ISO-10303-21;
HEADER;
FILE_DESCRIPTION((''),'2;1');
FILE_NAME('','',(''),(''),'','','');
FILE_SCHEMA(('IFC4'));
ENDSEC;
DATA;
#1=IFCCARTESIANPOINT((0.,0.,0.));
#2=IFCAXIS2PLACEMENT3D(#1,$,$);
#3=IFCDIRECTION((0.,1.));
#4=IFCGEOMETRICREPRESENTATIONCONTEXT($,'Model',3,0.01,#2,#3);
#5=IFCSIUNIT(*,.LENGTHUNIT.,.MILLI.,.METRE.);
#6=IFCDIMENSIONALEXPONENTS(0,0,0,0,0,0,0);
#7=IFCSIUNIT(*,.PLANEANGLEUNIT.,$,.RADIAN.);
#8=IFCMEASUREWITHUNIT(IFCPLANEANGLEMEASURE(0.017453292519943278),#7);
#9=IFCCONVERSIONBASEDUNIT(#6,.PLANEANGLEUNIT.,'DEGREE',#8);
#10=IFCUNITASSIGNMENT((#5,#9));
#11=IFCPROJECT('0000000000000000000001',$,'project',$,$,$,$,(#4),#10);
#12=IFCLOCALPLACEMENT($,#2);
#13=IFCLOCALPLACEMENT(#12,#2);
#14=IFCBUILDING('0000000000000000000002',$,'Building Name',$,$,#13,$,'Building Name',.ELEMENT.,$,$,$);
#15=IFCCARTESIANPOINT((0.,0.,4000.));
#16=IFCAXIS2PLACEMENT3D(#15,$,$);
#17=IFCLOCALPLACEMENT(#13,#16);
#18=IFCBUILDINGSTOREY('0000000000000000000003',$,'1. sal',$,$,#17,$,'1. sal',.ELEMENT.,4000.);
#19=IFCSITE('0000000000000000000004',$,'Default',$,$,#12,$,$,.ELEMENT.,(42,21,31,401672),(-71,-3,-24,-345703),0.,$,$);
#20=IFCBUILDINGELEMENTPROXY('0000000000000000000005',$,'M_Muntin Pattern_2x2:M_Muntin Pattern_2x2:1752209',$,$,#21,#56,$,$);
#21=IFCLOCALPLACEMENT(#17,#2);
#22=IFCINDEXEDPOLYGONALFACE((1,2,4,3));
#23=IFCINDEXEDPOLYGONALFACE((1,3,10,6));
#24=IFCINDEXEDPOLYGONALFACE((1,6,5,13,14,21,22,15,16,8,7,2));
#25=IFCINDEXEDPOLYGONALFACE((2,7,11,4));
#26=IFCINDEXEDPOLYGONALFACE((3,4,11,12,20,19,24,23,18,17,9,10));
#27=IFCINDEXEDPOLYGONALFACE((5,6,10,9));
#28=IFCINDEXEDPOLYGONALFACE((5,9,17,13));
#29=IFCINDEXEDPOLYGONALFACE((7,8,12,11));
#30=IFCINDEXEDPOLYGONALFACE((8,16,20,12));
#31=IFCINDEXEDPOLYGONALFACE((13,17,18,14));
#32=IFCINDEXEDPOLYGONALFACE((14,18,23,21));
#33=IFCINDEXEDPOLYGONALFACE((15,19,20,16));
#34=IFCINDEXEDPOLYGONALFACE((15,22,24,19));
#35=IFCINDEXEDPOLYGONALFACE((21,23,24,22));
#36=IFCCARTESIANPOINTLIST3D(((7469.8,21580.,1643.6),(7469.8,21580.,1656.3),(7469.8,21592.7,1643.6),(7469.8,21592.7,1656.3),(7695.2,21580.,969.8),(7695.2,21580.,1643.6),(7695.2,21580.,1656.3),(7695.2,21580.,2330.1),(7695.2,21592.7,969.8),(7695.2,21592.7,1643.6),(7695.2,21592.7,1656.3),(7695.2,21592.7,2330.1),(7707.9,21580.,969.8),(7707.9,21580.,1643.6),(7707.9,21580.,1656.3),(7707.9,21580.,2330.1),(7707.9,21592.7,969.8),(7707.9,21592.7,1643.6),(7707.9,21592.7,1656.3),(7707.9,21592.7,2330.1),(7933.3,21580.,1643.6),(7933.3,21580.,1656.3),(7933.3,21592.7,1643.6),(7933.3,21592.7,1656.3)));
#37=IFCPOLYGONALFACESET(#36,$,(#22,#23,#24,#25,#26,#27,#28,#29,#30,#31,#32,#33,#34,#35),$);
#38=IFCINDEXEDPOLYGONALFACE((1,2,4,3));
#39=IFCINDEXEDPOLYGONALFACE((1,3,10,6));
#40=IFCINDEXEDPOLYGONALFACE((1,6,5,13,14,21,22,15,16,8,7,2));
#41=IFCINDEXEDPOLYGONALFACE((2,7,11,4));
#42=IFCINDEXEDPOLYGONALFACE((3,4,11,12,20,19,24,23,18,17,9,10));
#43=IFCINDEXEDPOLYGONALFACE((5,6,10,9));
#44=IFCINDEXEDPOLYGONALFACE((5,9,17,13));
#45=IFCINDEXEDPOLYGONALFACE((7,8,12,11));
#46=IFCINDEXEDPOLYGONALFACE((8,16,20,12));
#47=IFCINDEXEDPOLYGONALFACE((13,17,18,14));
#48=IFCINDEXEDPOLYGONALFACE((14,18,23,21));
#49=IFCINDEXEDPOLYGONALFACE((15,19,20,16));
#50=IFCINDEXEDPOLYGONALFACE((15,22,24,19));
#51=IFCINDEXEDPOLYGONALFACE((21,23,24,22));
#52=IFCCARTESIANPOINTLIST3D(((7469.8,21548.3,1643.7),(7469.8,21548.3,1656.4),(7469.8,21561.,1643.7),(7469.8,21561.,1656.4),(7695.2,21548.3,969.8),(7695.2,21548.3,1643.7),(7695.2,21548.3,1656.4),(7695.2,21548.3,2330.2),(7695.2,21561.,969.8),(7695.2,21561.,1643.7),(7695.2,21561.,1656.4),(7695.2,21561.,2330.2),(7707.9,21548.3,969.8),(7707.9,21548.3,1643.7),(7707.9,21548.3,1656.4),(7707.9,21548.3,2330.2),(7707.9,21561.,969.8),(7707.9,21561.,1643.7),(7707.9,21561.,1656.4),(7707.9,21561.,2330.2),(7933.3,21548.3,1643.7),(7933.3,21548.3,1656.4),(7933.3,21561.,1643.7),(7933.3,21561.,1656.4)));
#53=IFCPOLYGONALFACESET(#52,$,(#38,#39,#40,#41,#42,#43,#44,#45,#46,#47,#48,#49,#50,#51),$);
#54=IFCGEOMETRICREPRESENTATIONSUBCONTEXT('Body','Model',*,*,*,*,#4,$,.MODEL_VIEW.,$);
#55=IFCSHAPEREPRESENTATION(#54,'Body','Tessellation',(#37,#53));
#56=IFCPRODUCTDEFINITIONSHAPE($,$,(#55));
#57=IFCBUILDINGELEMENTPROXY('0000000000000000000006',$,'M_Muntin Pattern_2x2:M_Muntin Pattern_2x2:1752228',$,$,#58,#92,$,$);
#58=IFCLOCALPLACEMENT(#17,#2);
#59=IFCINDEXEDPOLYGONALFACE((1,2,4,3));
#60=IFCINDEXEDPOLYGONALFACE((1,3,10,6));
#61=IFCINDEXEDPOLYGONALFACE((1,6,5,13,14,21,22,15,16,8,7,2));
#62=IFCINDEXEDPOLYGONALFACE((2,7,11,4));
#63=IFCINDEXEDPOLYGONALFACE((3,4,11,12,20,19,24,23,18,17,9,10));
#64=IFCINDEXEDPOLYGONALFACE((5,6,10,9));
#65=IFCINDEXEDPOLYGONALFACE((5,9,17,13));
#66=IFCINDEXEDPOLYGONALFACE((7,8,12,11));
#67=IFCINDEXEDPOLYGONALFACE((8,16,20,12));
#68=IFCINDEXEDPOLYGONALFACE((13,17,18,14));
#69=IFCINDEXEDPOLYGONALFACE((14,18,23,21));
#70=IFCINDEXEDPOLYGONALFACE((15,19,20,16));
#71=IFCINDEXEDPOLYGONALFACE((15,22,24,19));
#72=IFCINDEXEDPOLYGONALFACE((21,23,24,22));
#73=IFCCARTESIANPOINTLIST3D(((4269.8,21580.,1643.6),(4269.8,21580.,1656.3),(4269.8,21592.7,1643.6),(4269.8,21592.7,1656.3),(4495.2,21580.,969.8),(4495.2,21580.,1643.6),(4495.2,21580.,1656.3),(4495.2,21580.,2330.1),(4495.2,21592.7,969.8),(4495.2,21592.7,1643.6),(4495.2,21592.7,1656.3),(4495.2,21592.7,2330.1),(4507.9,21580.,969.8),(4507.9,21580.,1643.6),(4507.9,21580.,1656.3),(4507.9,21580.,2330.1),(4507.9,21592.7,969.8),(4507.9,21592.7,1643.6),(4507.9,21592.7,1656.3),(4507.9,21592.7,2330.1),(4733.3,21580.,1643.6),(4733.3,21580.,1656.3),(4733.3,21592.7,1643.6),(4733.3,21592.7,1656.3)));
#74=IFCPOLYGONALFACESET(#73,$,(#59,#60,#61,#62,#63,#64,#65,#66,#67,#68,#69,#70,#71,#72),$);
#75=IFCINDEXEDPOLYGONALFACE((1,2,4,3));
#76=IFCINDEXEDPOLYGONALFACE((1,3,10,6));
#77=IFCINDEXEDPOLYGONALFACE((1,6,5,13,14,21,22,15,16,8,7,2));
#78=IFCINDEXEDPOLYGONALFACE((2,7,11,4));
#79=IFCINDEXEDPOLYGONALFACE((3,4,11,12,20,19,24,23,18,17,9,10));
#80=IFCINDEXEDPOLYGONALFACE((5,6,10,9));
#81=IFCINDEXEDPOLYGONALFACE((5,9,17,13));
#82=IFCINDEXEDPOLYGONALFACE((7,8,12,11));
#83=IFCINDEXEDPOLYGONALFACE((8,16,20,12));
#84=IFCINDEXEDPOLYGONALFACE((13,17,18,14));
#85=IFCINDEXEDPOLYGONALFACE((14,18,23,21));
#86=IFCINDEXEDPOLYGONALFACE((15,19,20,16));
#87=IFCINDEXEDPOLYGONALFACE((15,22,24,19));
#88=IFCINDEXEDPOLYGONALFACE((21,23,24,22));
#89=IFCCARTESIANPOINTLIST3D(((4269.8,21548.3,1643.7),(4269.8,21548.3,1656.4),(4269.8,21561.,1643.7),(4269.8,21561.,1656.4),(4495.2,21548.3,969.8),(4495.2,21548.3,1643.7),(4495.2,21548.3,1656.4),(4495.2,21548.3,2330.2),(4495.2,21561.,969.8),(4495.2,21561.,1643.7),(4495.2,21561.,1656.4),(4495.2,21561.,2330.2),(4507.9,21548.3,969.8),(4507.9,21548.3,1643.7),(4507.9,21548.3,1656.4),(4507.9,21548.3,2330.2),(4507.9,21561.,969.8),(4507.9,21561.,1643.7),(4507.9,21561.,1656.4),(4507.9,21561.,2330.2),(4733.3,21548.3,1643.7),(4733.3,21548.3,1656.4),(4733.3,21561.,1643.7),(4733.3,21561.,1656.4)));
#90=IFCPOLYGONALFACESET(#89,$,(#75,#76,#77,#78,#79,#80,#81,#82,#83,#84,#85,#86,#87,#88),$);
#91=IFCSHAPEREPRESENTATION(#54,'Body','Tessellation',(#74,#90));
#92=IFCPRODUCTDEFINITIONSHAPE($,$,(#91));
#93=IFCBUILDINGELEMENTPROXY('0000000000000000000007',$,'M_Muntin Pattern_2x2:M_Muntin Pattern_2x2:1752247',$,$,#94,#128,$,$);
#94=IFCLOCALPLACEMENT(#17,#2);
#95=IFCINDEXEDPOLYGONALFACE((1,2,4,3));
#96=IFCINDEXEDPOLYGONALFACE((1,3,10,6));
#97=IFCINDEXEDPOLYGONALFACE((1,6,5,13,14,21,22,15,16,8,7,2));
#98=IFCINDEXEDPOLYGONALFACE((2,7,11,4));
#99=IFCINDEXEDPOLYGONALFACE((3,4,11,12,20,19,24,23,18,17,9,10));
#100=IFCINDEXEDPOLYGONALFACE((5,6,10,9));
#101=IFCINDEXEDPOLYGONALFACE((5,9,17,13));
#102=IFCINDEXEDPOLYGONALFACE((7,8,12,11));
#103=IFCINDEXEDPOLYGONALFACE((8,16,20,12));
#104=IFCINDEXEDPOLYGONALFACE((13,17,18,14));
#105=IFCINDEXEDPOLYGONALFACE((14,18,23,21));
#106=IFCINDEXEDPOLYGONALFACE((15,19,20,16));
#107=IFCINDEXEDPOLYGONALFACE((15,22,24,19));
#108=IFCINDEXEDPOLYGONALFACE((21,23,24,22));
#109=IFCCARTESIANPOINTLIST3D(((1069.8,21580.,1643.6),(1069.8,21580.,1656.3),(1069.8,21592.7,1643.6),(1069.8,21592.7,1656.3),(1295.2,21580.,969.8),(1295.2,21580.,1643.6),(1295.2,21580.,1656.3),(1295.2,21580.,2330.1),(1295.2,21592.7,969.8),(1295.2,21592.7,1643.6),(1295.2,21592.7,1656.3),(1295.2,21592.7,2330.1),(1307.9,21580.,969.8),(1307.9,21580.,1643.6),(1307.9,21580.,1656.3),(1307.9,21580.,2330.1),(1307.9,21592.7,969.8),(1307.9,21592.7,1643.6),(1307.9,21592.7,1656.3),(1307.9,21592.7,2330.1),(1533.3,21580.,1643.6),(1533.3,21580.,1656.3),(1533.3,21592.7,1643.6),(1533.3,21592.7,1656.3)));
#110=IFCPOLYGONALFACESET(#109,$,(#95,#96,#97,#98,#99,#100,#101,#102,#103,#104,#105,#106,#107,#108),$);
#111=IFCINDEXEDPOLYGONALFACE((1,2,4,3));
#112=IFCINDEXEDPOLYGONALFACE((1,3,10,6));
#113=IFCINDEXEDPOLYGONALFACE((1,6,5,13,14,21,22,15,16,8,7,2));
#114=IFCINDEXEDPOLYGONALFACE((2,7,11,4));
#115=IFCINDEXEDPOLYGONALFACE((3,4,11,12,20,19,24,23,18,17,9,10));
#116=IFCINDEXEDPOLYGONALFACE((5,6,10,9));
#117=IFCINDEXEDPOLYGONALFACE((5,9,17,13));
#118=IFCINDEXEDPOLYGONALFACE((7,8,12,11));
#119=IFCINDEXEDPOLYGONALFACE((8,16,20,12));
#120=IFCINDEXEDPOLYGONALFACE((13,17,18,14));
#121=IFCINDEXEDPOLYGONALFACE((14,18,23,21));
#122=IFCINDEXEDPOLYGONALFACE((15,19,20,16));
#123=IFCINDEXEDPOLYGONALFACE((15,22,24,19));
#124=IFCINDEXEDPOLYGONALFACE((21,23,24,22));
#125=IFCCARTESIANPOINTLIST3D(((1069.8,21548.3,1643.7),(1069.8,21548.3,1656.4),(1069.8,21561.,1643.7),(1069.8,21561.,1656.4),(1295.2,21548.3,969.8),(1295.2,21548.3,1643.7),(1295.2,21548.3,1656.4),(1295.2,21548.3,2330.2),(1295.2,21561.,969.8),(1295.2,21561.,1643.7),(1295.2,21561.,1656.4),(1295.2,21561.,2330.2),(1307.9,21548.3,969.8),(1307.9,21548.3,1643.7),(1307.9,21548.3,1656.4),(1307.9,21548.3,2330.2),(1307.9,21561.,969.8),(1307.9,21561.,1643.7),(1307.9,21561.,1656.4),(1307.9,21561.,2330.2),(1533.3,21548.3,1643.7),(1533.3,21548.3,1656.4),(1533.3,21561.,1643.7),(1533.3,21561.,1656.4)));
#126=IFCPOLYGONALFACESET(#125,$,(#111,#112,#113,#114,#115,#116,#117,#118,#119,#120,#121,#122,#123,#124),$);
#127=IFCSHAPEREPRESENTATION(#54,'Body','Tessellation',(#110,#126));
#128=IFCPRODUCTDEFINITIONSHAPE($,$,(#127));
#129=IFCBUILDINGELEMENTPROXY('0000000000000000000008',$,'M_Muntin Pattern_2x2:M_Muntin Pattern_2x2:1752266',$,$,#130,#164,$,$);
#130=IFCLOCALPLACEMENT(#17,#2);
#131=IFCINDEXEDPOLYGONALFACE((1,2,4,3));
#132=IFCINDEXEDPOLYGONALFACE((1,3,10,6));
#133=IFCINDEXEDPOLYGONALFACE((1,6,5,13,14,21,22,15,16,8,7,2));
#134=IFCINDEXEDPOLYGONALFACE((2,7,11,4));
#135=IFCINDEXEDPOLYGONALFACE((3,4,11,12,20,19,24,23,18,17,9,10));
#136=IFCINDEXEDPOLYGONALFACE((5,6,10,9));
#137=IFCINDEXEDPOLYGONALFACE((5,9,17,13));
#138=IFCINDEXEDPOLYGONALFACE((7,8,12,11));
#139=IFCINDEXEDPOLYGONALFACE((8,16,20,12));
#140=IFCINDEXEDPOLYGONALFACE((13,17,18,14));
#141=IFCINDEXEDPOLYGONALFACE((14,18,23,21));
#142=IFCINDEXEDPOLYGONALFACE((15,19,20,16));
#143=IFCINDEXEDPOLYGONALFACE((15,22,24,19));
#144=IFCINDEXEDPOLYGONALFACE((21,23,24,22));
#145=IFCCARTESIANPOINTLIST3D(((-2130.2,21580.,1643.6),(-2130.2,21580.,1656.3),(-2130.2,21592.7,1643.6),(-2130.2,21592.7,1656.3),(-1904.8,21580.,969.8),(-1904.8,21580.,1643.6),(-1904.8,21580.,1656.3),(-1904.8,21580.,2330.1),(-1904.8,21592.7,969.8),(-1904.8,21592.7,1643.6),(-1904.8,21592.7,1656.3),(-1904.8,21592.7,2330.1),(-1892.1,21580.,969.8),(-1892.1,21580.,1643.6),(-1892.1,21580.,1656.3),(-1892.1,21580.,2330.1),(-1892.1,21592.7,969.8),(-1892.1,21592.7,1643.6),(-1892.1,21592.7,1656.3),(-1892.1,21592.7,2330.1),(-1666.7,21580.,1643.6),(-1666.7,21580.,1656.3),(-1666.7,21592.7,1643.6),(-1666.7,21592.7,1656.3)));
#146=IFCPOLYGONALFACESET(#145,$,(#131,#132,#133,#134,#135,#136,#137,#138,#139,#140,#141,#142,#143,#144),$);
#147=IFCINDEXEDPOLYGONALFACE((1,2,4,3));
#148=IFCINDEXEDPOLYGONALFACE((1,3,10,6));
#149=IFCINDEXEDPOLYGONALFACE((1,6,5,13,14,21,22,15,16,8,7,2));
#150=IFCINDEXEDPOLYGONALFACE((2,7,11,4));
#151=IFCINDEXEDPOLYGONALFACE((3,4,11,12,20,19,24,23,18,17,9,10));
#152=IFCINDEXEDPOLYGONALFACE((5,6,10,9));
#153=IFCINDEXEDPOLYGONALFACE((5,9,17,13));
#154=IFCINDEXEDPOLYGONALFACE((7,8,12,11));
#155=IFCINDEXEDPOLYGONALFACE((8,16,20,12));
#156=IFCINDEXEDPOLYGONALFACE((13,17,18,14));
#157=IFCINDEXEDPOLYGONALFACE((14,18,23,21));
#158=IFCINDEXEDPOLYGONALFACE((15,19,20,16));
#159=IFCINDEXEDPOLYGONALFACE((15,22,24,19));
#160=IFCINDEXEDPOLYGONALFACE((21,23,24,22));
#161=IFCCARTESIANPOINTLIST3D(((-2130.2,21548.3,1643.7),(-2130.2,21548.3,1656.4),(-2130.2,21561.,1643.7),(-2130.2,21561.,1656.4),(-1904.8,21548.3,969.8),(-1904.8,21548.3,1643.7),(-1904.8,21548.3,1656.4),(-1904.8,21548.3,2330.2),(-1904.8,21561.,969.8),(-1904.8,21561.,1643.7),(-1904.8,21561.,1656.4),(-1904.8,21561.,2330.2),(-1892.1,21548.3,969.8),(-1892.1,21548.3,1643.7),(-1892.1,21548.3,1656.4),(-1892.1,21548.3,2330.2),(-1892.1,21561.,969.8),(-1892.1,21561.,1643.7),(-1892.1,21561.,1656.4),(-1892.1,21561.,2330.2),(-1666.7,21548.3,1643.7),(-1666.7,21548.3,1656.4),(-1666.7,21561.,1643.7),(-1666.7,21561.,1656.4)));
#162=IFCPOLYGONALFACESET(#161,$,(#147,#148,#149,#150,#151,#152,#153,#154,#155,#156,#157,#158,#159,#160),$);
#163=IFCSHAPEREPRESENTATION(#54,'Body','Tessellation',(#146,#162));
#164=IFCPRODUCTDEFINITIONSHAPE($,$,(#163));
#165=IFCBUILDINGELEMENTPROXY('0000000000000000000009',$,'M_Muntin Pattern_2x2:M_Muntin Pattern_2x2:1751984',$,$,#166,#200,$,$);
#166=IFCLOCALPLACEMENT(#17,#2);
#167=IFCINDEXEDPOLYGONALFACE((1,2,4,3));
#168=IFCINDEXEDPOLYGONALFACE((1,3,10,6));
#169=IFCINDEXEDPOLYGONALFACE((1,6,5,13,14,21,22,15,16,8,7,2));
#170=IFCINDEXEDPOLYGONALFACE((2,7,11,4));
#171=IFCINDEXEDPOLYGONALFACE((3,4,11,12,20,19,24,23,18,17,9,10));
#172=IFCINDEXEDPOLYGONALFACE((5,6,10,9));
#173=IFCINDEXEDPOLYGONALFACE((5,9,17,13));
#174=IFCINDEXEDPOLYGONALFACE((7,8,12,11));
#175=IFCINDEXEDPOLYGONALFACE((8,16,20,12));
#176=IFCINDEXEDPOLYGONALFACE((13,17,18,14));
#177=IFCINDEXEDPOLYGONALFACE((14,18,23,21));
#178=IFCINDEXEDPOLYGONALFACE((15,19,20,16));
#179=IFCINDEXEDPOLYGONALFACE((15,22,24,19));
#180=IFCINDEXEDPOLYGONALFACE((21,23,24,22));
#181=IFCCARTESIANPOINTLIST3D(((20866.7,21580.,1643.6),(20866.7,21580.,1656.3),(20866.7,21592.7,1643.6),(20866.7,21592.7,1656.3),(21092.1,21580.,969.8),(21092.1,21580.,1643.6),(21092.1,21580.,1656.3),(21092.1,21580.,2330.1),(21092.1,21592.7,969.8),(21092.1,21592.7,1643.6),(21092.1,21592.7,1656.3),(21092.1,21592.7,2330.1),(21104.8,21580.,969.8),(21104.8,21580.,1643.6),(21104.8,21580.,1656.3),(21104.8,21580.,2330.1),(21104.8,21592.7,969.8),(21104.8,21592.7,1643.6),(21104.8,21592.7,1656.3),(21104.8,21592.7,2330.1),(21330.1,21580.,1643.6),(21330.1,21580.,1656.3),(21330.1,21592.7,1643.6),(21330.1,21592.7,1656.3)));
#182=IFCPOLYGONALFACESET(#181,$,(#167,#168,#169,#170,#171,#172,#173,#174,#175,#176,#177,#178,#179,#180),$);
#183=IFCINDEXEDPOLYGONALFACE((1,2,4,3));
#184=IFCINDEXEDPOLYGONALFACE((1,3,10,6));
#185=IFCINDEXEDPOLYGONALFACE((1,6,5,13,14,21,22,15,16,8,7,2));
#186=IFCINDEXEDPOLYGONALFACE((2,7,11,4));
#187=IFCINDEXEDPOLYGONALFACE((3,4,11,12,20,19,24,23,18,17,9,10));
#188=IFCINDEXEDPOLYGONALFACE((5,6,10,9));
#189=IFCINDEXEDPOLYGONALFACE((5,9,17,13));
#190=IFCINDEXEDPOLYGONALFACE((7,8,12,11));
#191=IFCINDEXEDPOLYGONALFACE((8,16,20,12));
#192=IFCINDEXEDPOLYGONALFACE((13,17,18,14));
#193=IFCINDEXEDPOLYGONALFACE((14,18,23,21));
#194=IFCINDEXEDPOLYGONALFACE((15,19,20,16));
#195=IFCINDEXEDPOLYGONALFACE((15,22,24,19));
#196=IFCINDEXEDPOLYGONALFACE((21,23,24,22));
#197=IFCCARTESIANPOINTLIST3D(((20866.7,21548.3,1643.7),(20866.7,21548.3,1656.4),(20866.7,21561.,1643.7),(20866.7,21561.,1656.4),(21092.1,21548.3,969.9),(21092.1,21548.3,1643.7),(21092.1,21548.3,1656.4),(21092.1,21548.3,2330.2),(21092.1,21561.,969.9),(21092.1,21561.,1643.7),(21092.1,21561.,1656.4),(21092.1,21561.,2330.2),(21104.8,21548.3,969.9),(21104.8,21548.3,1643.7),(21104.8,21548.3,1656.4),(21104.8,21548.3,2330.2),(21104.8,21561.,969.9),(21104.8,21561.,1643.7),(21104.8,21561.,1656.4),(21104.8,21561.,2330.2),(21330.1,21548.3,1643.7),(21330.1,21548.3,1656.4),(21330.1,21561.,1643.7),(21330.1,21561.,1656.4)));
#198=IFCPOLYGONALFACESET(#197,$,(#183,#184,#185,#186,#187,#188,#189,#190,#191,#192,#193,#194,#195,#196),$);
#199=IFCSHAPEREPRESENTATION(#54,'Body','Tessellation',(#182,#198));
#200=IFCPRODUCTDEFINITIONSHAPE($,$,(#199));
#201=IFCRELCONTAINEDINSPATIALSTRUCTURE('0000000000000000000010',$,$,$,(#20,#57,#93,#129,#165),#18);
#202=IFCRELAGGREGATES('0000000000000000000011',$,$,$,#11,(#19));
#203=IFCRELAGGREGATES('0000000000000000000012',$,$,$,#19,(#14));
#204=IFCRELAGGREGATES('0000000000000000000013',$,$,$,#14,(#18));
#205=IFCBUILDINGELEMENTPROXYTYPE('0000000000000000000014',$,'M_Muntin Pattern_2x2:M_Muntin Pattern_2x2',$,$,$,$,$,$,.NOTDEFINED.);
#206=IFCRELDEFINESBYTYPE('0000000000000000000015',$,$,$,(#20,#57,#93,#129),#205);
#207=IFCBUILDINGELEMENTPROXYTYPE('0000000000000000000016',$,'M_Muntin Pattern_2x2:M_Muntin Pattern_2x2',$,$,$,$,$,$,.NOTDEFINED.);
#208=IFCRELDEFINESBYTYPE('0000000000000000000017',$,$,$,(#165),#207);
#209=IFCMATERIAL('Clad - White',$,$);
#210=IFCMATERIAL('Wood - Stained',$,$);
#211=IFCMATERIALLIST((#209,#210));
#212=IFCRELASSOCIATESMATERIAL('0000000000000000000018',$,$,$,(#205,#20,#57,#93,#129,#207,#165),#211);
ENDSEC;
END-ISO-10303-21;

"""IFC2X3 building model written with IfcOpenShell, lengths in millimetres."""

from ifc_helpers import new_model, entity, si_unit, converted_unit, direction, frame, origin, place, context, subcontext, project, spatial, polyline, outline, extrude, source, transform, mapped, material, material_list, type_object, type_shapes, element, save


model = new_model("IFC2X3")

# Units and contexts
model_context = context("Model", 3, precision=0.01, world=origin(), true_north=direction((0.0, 1.0)))
body_context = subcontext(model_context, "Body", "Model", "MODEL_VIEW")
ifc_project = project(units=[si_unit("LENGTHUNIT", "METRE", prefix="MILLI"), converted_unit("PLANEANGLEUNIT", "DEGREE", entity("IfcPlaneAngleMeasure", 0.017453292519943278), si_unit("PLANEANGLEUNIT", "RADIAN"), dimensions=[0, 0, 0, 0, 0, 0, 0])], contexts=[model_context])

# Site, building, storey
site_placement = place(None, origin())
site = spatial("IfcSite", under=ifc_project, at=site_placement, Name="Default", CompositionType="ELEMENT", RefLatitude=(42, 21, 31, 401672), RefLongitude=(-71, -3, -24, -345703), RefElevation=0.0)
building_placement = place(site_placement, origin())
building = spatial("IfcBuilding", under=site, at=building_placement, Name="Building Name", LongName="Building Name", CompositionType="ELEMENT")
storey_placement = place(building_placement, frame((0.0, 0.0, 4000.0)))
storey = spatial("IfcBuildingStorey", under=building, at=storey_placement, Name="1. sal", LongName="1. sal", CompositionType="ELEMENT", Elevation=4000.0)

# Building element proxies
ifc_material_1 = material(Name="Clad - White")
ifc_material_2 = material(Name="Wood - Stained")
ifc_material_list = material_list([ifc_material_1, ifc_material_2])
building_element_proxy_type_1 = type_object("IfcBuildingElementProxyType", Name="M_Muntin Pattern_2x2:M_Muntin Pattern_2x2", PredefinedType="NOTDEFINED", material=ifc_material_list)
shared_shape_1 = source(origin(), body_context, "Body", "SweptSolid", [
    extrude(outline(polyline([(6.4, -6.4), (680.1, -6.4), (680.1, 6.3), (6.4, 6.3), (6.4, 231.7), (-6.3, 231.7), (-6.3, 6.3), (-680.2, 6.3), (-680.2, -6.4), (-6.3, -6.4), (-6.3, -231.7), (6.4, -231.7), (6.4, -6.4)])), frame((0.0, 9.5, 680.1), z_axis=(0.0, 1.0, 0.0), x_axis=(0.0, 0.0, 1.0)), (0.0, 0.0, 1.0), 12.7),
    extrude(outline(polyline([(6.4, -6.4), (680.2, -6.4), (680.2, 6.3), (6.4, 6.3), (6.4, 231.7), (-6.3, 231.7), (-6.3, 6.3), (-680.2, 6.3), (-680.2, -6.4), (-6.3, -6.4), (-6.3, -231.7), (6.4, -231.7), (6.4, -6.4)])), frame((0.0, -22.2, 680.2), z_axis=(0.0, 1.0, 0.0), x_axis=(0.0, 0.0, 1.0)), (0.0, 0.0, 1.0), 12.7),
])
type_shapes(building_element_proxy_type_1, [shared_shape_1])
for number, where, name in (
    (1, (7701.6, 21570.5, 969.8), "M_Muntin Pattern_2x2:M_Muntin Pattern_2x2:1752209"),
    (2, (4501.6, 21570.5, 969.8), "M_Muntin Pattern_2x2:M_Muntin Pattern_2x2:1752228"),
    (3, (1301.6, 21570.5, 969.8), "M_Muntin Pattern_2x2:M_Muntin Pattern_2x2:1752247"),
    (4, (-1898.4, 21570.5, 969.8), "M_Muntin Pattern_2x2:M_Muntin Pattern_2x2:1752266"),
):
    element("IfcBuildingElementProxy", number, at=place(storey_placement, frame(where)), inside=storey, type_object=building_element_proxy_type_1, material=ifc_material_list, Name=name, context=body_context, shape_type="MappedRepresentation", body=[
        mapped(shared_shape_1, transform((0.0, 0.0, 0.0), scale=1.0)),
    ])
building_element_proxy_type_2 = type_object("IfcBuildingElementProxyType", Name="M_Muntin Pattern_2x2:M_Muntin Pattern_2x2", PredefinedType="NOTDEFINED", material=ifc_material_list)
shared_shape_2 = source(origin(), body_context, "Body", "SweptSolid", [
    extrude(outline(polyline([(6.4, -6.4), (680.1, -6.4), (680.1, 6.3), (6.4, 6.3), (6.4, 231.7), (-6.3, 231.7), (-6.3, 6.3), (-680.2, 6.3), (-680.2, -6.4), (-6.3, -6.4), (-6.3, -231.7), (6.4, -231.7), (6.4, -6.4)])), frame((0.0, -22.2, 680.1), z_axis=(0.0, 1.0, 0.0), x_axis=(0.0, 0.0, 1.0)), (0.0, 0.0, 1.0), 12.7),
    extrude(outline(polyline([(6.4, -6.4), (680.2, -6.4), (680.2, 6.3), (6.4, 6.3), (6.4, 231.7), (-6.3, 231.7), (-6.3, 6.3), (-680.2, 6.3), (-680.2, -6.4), (-6.3, -6.4), (-6.3, -231.7), (6.4, -231.7), (6.4, -6.4)])), frame((0.0, 9.5, 680.2), z_axis=(0.0, 1.0, 0.0), x_axis=(0.0, 0.0, 1.0)), (0.0, 0.0, 1.0), 12.7),
])
type_shapes(building_element_proxy_type_2, [shared_shape_2])
for number, where, z_axis, x_axis, name in (
    (5, (21098.4, 21570.5, 969.9), (0.0, 0.0, 1.0), (-1.0, 0.0, 0.0), "M_Muntin Pattern_2x2:M_Muntin Pattern_2x2:1751984"),
):
    element("IfcBuildingElementProxy", number, at=place(storey_placement, frame(where, z_axis=z_axis, x_axis=x_axis)), inside=storey, type_object=building_element_proxy_type_2, material=ifc_material_list, Name=name, context=body_context, shape_type="MappedRepresentation", body=[
        mapped(shared_shape_2, transform((0.0, 0.0, 0.0), scale=1.0)),
    ])

save(model, "model.ifc")
